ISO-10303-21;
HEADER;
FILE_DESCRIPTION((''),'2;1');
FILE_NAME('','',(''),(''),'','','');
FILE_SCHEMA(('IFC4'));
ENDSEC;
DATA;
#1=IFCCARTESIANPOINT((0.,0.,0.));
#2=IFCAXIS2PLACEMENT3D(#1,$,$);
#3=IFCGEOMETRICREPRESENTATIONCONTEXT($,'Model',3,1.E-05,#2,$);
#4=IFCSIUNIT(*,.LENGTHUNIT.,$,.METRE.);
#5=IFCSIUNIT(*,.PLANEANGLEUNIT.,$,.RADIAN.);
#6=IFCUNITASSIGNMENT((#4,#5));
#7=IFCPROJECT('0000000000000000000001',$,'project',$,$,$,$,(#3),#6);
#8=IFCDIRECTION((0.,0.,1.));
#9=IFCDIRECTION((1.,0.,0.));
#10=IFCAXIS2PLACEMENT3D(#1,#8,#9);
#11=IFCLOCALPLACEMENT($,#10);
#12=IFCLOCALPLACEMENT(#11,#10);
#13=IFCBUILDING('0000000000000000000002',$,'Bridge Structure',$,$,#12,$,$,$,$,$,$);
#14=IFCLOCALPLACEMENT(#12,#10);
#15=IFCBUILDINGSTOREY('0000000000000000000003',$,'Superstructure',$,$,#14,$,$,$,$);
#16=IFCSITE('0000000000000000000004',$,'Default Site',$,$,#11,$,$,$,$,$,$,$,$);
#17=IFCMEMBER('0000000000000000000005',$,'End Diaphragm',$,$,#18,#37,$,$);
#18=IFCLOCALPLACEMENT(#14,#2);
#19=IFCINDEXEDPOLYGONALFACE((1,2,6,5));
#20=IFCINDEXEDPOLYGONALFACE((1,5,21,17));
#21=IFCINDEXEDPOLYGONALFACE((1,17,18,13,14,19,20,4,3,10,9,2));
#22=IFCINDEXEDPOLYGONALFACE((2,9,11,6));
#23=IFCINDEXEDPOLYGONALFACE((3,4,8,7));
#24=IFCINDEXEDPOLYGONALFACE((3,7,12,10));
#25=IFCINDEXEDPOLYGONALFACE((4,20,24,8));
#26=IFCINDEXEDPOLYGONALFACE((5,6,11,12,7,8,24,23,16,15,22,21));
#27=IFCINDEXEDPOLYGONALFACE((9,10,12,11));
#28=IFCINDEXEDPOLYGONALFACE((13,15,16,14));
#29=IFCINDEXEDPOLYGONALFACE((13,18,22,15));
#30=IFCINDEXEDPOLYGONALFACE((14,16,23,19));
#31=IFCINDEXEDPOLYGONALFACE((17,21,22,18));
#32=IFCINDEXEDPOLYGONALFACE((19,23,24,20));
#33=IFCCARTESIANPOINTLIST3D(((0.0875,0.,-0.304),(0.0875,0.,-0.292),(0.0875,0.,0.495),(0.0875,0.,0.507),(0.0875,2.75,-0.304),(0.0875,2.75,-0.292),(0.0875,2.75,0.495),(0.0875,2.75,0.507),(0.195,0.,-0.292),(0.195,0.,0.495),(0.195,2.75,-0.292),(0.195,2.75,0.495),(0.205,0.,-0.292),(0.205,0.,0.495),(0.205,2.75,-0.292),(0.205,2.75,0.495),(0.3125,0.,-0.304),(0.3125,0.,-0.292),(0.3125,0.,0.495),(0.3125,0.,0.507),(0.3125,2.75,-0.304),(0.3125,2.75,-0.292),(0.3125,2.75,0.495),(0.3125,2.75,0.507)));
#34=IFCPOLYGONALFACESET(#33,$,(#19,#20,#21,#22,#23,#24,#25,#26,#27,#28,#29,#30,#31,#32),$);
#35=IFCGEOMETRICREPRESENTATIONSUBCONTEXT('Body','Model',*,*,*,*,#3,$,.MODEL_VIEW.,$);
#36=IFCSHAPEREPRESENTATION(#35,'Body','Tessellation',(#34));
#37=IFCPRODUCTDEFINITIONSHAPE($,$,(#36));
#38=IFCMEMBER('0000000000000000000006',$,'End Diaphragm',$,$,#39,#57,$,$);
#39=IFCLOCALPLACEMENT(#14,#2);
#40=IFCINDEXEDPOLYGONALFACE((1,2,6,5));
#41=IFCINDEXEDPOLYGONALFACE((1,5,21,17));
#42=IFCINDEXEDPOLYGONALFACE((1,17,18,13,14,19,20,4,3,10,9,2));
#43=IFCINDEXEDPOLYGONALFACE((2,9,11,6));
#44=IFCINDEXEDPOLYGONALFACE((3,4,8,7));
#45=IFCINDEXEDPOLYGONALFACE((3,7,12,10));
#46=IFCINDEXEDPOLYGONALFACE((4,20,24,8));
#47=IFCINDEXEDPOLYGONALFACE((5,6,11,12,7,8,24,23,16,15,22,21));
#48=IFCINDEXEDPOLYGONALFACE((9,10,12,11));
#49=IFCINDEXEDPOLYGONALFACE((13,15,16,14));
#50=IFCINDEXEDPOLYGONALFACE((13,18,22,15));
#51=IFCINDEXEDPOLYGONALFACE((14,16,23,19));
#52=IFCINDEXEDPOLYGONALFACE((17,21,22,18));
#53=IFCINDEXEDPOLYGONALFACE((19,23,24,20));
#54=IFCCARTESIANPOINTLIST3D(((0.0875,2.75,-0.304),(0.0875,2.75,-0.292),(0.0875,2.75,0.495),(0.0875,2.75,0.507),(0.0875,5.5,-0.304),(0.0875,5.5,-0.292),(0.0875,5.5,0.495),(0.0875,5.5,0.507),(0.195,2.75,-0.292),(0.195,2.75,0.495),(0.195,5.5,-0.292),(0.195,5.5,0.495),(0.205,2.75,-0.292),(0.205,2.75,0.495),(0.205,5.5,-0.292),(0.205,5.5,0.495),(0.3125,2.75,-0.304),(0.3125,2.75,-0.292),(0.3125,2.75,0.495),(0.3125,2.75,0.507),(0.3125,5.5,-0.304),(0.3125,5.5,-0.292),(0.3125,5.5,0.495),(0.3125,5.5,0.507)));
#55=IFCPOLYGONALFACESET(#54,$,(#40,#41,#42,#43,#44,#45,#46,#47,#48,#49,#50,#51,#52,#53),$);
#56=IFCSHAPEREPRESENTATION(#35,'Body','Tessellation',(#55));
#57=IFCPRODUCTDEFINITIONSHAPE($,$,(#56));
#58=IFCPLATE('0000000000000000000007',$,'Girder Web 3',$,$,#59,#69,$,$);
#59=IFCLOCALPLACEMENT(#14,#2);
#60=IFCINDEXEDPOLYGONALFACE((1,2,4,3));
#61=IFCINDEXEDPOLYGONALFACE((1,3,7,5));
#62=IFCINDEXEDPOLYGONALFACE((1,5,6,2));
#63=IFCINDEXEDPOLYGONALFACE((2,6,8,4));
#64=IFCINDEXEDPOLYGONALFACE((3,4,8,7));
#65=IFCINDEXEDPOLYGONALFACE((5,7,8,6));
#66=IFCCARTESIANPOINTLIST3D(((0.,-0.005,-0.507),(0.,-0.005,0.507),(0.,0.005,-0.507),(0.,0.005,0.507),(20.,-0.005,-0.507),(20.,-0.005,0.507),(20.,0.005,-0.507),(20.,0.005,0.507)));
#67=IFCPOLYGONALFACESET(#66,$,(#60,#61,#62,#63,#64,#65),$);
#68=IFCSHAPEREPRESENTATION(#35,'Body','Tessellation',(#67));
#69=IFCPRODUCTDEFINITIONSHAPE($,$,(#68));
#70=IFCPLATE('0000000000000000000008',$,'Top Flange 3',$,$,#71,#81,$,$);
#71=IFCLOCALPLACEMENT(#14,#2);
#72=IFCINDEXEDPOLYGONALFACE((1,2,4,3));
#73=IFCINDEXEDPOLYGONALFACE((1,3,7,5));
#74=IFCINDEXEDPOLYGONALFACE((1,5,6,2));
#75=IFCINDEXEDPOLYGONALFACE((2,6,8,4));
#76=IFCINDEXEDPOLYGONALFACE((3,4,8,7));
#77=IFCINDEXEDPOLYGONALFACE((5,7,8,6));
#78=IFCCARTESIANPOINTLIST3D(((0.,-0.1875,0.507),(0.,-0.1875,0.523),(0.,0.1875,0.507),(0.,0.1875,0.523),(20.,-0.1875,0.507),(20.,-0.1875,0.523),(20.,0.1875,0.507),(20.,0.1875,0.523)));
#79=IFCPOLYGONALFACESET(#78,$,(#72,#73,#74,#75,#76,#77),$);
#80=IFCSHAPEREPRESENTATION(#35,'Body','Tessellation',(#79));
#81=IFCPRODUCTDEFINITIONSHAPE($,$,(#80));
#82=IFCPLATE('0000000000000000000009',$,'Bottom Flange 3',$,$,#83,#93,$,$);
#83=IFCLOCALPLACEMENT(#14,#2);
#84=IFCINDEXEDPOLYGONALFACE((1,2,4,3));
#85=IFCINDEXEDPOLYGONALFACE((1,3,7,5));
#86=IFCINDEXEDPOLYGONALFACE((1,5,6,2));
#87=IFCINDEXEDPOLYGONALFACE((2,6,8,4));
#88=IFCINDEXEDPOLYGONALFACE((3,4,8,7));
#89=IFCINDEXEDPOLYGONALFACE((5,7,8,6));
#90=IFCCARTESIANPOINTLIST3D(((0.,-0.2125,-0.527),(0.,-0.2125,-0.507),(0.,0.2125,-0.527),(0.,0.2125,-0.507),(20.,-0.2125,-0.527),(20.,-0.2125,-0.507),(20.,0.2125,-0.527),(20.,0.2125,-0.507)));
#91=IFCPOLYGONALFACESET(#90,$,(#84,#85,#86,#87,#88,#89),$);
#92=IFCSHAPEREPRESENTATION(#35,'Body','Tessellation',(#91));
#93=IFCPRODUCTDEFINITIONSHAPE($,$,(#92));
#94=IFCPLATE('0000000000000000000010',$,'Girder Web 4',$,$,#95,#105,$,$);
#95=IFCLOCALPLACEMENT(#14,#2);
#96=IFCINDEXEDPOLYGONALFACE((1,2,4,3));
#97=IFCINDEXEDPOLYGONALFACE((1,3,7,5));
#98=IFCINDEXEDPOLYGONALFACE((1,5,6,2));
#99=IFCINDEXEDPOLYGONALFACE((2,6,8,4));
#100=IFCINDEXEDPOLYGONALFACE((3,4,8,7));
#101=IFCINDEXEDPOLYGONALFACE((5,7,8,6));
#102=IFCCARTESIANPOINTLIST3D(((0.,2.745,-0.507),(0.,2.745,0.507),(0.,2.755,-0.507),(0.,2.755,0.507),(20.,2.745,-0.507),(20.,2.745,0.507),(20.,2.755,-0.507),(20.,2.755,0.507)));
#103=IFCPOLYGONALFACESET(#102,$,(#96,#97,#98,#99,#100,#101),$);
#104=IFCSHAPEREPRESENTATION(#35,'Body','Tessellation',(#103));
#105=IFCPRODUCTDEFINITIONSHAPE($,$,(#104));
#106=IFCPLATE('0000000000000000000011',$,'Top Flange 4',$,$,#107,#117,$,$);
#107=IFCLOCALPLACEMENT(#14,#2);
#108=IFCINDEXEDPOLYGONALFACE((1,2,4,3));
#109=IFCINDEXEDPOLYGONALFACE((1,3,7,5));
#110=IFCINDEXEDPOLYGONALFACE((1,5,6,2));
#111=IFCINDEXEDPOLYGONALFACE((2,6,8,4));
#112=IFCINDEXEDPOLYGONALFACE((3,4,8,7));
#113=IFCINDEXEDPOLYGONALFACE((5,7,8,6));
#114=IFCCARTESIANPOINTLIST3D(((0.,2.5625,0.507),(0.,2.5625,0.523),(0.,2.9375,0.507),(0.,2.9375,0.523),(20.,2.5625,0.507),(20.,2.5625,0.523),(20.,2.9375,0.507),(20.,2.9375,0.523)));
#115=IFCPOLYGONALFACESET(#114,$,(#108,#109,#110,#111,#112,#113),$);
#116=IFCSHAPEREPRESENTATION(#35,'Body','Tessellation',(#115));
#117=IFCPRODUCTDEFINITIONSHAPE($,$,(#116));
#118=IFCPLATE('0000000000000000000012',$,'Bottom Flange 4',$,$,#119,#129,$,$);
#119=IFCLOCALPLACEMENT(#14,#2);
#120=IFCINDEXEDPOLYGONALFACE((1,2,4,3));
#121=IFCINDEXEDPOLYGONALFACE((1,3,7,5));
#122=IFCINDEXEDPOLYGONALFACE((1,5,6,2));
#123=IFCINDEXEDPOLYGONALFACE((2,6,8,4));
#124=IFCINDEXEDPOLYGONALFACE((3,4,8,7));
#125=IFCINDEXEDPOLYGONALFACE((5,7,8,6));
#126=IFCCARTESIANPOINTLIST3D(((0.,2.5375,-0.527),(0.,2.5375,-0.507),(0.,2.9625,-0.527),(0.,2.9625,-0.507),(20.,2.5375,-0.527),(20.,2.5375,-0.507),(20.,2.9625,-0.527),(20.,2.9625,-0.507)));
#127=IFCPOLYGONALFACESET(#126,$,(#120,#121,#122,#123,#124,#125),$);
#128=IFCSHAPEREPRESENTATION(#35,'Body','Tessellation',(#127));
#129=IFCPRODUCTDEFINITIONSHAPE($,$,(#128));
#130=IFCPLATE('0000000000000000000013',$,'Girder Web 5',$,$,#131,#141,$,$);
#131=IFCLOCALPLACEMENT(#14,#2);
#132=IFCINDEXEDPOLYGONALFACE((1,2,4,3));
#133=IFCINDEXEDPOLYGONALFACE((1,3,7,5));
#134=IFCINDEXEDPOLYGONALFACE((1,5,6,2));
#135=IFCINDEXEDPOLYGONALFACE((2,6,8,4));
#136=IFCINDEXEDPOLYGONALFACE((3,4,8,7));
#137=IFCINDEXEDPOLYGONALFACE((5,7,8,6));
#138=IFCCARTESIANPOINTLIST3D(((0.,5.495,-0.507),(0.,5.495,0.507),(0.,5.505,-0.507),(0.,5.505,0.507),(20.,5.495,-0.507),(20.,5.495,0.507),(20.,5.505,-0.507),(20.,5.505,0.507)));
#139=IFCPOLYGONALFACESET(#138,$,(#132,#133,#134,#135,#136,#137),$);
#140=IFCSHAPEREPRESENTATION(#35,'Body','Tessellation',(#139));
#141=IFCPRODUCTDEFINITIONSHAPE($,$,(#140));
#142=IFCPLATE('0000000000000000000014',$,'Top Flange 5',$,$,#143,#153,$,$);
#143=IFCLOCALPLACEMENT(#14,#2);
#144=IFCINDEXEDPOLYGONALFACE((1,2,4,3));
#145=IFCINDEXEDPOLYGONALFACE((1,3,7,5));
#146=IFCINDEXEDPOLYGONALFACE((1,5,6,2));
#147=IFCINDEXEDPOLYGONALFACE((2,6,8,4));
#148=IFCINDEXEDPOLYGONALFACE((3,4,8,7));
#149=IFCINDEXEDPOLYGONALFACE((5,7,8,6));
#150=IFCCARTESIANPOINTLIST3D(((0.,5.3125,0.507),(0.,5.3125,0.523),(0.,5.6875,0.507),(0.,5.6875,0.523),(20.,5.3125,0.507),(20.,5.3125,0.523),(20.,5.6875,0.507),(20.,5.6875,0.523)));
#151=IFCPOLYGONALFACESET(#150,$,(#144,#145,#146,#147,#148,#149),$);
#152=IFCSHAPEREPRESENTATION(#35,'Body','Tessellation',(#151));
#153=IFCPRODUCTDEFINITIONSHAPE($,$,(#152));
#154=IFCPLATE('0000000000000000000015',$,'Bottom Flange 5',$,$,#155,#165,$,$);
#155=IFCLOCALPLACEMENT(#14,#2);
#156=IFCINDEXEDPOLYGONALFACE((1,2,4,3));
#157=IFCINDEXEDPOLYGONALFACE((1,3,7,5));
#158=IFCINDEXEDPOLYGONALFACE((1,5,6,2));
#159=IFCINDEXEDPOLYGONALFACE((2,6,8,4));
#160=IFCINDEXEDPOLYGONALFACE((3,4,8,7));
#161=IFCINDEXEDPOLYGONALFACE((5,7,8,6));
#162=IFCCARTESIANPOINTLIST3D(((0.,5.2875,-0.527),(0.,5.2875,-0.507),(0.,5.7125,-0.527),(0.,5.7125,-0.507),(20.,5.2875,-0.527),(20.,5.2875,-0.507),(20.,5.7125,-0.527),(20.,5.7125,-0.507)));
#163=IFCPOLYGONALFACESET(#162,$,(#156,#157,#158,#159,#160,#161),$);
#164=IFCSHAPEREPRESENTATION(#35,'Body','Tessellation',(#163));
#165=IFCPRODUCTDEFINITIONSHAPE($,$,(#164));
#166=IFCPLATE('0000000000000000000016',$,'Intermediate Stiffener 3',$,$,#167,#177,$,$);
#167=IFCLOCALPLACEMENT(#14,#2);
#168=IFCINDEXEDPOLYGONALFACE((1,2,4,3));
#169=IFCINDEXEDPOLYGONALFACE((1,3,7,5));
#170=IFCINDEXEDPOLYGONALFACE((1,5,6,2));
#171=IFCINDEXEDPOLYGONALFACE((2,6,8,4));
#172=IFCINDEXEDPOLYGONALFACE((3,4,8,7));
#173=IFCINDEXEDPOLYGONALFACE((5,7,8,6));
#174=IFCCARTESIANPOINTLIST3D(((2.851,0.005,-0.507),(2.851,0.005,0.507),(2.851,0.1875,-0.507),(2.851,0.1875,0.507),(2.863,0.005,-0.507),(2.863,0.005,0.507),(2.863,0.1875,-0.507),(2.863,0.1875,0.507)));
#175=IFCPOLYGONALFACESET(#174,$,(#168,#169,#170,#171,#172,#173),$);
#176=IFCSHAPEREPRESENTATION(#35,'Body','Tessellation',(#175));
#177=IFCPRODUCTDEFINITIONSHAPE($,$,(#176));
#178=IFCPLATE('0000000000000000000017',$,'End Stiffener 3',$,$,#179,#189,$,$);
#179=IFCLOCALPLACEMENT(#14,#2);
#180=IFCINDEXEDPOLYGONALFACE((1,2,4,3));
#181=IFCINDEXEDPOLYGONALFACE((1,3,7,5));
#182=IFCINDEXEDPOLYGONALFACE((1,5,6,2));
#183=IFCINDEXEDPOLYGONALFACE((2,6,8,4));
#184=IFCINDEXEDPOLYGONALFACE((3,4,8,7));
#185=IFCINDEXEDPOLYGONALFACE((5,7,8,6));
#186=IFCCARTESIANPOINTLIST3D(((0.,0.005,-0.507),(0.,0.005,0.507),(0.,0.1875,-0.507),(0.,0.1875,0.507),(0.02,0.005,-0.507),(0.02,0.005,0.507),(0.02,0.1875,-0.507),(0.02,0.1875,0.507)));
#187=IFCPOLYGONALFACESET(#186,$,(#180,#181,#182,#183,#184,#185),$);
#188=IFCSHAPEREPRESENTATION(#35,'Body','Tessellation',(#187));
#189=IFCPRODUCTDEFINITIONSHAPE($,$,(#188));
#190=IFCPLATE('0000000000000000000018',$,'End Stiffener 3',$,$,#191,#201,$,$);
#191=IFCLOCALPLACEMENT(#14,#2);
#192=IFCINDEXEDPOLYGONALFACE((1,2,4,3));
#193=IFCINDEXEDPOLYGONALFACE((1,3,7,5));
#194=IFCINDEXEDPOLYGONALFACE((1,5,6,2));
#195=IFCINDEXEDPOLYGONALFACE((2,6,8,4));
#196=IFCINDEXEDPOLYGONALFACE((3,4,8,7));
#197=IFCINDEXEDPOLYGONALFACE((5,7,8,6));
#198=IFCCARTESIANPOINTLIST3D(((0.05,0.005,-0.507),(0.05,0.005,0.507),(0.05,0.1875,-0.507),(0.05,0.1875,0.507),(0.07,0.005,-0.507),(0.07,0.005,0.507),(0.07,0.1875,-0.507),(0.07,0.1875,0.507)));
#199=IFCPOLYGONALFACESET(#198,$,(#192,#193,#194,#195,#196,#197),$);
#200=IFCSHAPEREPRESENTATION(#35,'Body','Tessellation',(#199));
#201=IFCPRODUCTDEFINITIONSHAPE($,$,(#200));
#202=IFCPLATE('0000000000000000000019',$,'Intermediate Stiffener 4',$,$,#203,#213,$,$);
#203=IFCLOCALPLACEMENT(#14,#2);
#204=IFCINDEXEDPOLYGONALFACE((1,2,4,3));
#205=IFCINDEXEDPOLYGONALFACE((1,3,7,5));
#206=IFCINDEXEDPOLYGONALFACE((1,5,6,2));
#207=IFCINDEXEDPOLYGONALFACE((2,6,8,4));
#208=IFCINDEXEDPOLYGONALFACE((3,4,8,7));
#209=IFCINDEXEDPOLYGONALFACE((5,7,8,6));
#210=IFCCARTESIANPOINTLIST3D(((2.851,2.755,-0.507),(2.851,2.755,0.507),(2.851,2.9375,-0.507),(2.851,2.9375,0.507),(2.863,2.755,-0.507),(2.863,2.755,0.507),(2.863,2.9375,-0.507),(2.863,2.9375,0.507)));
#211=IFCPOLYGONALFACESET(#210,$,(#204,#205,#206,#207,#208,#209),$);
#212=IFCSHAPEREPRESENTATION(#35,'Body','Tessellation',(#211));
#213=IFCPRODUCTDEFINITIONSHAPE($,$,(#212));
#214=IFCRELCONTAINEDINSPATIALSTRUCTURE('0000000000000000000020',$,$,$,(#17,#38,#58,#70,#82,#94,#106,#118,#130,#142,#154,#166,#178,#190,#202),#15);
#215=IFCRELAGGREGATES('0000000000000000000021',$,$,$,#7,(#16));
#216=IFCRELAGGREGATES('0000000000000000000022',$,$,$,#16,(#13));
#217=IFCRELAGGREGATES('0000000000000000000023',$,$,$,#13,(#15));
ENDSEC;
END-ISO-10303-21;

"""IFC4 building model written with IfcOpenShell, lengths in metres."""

from ifc_helpers import new_model, si_unit, frame, origin, origin_with_axes, origin_2d_with_axis, place, context, subcontext, project, spatial, rectangle, i_section, extrude, element, save


model = new_model("IFC4")

# Units and contexts
model_context = context("Model", 3, precision=1e-05, world=origin())
body_context = subcontext(model_context, "Body", "Model", "MODEL_VIEW")
ifc_project = project(units=[si_unit("LENGTHUNIT", "METRE"), si_unit("PLANEANGLEUNIT", "RADIAN")], contexts=[model_context])

# Site, building, storey
site_placement = place(None, origin_with_axes())
site = spatial("IfcSite", under=ifc_project, at=site_placement, Name="Default Site")
building_placement = place(site_placement, origin_with_axes())
building = spatial("IfcBuilding", under=site, at=building_placement, Name="Bridge Structure")
storey_placement = place(building_placement, origin_with_axes())
storey = spatial("IfcBuildingStorey", under=building, at=storey_placement, Name="Superstructure")

# Members
for number, where, z_axis, x_axis, name in (
    (1, (0.2, 0.0, 0.1015), (0.0, 1.0, 0.0), (-1.0, 0.0, 0.0), "End Diaphragm"),
    (2, (0.2, 2.75, 0.1015), (0.0, 1.0, 0.0), (-1.0, 0.0, 0.0), "End Diaphragm"),
):
    element("IfcMember", number, at=place(storey_placement, frame(where, z_axis=z_axis, x_axis=x_axis)), inside=storey, Name=name, context=body_context, shape_type="SweptSolid", body=[
        extrude(i_section(OverallWidth=0.225, OverallDepth=0.811, WebThickness=0.01, FlangeThickness=0.012, at=origin_2d_with_axis()), origin_with_axes(), (0.0, 0.0, 1.0), 2.75),
    ])

# Plates
plate_1_placement = place(storey_placement, frame((0.0, 0.0, 0.0), z_axis=(1.0, 0.0, 0.0), x_axis=(0.0, 1.0, 0.0)))
element("IfcPlate", 3, at=plate_1_placement, inside=storey, Name="Girder Web 3", context=body_context, shape_type="SweptSolid", body=[
    extrude(rectangle(XDim=0.01, YDim=1.014, at=origin_2d_with_axis()), origin_with_axes(), (0.0, 0.0, 1.0), 20.0),
])
plate_2_placement = place(storey_placement, frame((0.0, 0.0, 0.515), z_axis=(1.0, 0.0, 0.0), x_axis=(0.0, 1.0, 0.0)))
element("IfcPlate", 4, at=plate_2_placement, inside=storey, Name="Top Flange 3", context=body_context, shape_type="SweptSolid", body=[
    extrude(rectangle(XDim=0.375, YDim=0.016, at=origin_2d_with_axis()), origin_with_axes(), (0.0, 0.0, 1.0), 20.0),
])
plate_3_placement = place(storey_placement, frame((0.0, 0.0, -0.517), z_axis=(1.0, 0.0, 0.0), x_axis=(0.0, 1.0, 0.0)))
element("IfcPlate", 5, at=plate_3_placement, inside=storey, Name="Bottom Flange 3", context=body_context, shape_type="SweptSolid", body=[
    extrude(rectangle(XDim=0.425, YDim=0.02, at=origin_2d_with_axis()), origin_with_axes(), (0.0, 0.0, 1.0), 20.0),
])
plate_4_placement = place(storey_placement, frame((0.0, 2.75, 0.0), z_axis=(1.0, 0.0, 0.0), x_axis=(0.0, 1.0, 0.0)))
element("IfcPlate", 6, at=plate_4_placement, inside=storey, Name="Girder Web 4", context=body_context, shape_type="SweptSolid", body=[
    extrude(rectangle(XDim=0.01, YDim=1.014, at=origin_2d_with_axis()), origin_with_axes(), (0.0, 0.0, 1.0), 20.0),
])
plate_5_placement = place(storey_placement, frame((0.0, 2.75, 0.515), z_axis=(1.0, 0.0, 0.0), x_axis=(0.0, 1.0, 0.0)))
element("IfcPlate", 7, at=plate_5_placement, inside=storey, Name="Top Flange 4", context=body_context, shape_type="SweptSolid", body=[
    extrude(rectangle(XDim=0.375, YDim=0.016, at=origin_2d_with_axis()), origin_with_axes(), (0.0, 0.0, 1.0), 20.0),
])
plate_6_placement = place(storey_placement, frame((0.0, 2.75, -0.517), z_axis=(1.0, 0.0, 0.0), x_axis=(0.0, 1.0, 0.0)))
element("IfcPlate", 8, at=plate_6_placement, inside=storey, Name="Bottom Flange 4", context=body_context, shape_type="SweptSolid", body=[
    extrude(rectangle(XDim=0.425, YDim=0.02, at=origin_2d_with_axis()), origin_with_axes(), (0.0, 0.0, 1.0), 20.0),
])
plate_7_placement = place(storey_placement, frame((0.0, 5.5, 0.0), z_axis=(1.0, 0.0, 0.0), x_axis=(0.0, 1.0, 0.0)))
element("IfcPlate", 9, at=plate_7_placement, inside=storey, Name="Girder Web 5", context=body_context, shape_type="SweptSolid", body=[
    extrude(rectangle(XDim=0.01, YDim=1.014, at=origin_2d_with_axis()), origin_with_axes(), (0.0, 0.0, 1.0), 20.0),
])
plate_8_placement = place(storey_placement, frame((0.0, 5.5, 0.515), z_axis=(1.0, 0.0, 0.0), x_axis=(0.0, 1.0, 0.0)))
element("IfcPlate", 10, at=plate_8_placement, inside=storey, Name="Top Flange 5", context=body_context, shape_type="SweptSolid", body=[
    extrude(rectangle(XDim=0.375, YDim=0.016, at=origin_2d_with_axis()), origin_with_axes(), (0.0, 0.0, 1.0), 20.0),
])
plate_9_placement = place(storey_placement, frame((0.0, 5.5, -0.517), z_axis=(1.0, 0.0, 0.0), x_axis=(0.0, 1.0, 0.0)))
element("IfcPlate", 11, at=plate_9_placement, inside=storey, Name="Bottom Flange 5", context=body_context, shape_type="SweptSolid", body=[
    extrude(rectangle(XDim=0.425, YDim=0.02, at=origin_2d_with_axis()), origin_with_axes(), (0.0, 0.0, 1.0), 20.0),
])
plate_10_placement = place(storey_placement, frame((2.857, 0.0963, -0.507), z_axis=(0.0, 0.0, 1.0), x_axis=(1.0, 0.0, 0.0)))
element("IfcPlate", 12, at=plate_10_placement, inside=storey, Name="Intermediate Stiffener 3", context=body_context, shape_type="SweptSolid", body=[
    extrude(rectangle(XDim=0.012, YDim=0.1825, at=origin_2d_with_axis()), origin_with_axes(), (0.0, 0.0, 1.0), 1.014),
])
for number, where, z_axis, x_axis, name in (
    (13, (0.01, 0.0963, -0.507), (0.0, 0.0, 1.0), (1.0, 0.0, 0.0), "End Stiffener 3"),
    (14, (0.06, 0.0963, -0.507), (0.0, 0.0, 1.0), (1.0, 0.0, 0.0), "End Stiffener 3"),
):
    element("IfcPlate", number, at=place(storey_placement, frame(where, z_axis=z_axis, x_axis=x_axis)), inside=storey, Name=name, context=body_context, shape_type="SweptSolid", body=[
        extrude(rectangle(XDim=0.02, YDim=0.1825, at=origin_2d_with_axis()), origin_with_axes(), (0.0, 0.0, 1.0), 1.014),
    ])
for number, where, z_axis, x_axis, name in (
    (15, (2.857, 2.8462, -0.507), (0.0, 0.0, 1.0), (1.0, 0.0, 0.0), "Intermediate Stiffener 4"),
):
    element("IfcPlate", number, at=place(storey_placement, frame(where, z_axis=z_axis, x_axis=x_axis)), inside=storey, Name=name, context=body_context, shape_type="SweptSolid", body=[
        extrude(rectangle(XDim=0.012, YDim=0.1825, at=origin_2d_with_axis()), origin_with_axes(), (0.0, 0.0, 1.0), 1.014),
    ])

save(model, "model.ifc")
